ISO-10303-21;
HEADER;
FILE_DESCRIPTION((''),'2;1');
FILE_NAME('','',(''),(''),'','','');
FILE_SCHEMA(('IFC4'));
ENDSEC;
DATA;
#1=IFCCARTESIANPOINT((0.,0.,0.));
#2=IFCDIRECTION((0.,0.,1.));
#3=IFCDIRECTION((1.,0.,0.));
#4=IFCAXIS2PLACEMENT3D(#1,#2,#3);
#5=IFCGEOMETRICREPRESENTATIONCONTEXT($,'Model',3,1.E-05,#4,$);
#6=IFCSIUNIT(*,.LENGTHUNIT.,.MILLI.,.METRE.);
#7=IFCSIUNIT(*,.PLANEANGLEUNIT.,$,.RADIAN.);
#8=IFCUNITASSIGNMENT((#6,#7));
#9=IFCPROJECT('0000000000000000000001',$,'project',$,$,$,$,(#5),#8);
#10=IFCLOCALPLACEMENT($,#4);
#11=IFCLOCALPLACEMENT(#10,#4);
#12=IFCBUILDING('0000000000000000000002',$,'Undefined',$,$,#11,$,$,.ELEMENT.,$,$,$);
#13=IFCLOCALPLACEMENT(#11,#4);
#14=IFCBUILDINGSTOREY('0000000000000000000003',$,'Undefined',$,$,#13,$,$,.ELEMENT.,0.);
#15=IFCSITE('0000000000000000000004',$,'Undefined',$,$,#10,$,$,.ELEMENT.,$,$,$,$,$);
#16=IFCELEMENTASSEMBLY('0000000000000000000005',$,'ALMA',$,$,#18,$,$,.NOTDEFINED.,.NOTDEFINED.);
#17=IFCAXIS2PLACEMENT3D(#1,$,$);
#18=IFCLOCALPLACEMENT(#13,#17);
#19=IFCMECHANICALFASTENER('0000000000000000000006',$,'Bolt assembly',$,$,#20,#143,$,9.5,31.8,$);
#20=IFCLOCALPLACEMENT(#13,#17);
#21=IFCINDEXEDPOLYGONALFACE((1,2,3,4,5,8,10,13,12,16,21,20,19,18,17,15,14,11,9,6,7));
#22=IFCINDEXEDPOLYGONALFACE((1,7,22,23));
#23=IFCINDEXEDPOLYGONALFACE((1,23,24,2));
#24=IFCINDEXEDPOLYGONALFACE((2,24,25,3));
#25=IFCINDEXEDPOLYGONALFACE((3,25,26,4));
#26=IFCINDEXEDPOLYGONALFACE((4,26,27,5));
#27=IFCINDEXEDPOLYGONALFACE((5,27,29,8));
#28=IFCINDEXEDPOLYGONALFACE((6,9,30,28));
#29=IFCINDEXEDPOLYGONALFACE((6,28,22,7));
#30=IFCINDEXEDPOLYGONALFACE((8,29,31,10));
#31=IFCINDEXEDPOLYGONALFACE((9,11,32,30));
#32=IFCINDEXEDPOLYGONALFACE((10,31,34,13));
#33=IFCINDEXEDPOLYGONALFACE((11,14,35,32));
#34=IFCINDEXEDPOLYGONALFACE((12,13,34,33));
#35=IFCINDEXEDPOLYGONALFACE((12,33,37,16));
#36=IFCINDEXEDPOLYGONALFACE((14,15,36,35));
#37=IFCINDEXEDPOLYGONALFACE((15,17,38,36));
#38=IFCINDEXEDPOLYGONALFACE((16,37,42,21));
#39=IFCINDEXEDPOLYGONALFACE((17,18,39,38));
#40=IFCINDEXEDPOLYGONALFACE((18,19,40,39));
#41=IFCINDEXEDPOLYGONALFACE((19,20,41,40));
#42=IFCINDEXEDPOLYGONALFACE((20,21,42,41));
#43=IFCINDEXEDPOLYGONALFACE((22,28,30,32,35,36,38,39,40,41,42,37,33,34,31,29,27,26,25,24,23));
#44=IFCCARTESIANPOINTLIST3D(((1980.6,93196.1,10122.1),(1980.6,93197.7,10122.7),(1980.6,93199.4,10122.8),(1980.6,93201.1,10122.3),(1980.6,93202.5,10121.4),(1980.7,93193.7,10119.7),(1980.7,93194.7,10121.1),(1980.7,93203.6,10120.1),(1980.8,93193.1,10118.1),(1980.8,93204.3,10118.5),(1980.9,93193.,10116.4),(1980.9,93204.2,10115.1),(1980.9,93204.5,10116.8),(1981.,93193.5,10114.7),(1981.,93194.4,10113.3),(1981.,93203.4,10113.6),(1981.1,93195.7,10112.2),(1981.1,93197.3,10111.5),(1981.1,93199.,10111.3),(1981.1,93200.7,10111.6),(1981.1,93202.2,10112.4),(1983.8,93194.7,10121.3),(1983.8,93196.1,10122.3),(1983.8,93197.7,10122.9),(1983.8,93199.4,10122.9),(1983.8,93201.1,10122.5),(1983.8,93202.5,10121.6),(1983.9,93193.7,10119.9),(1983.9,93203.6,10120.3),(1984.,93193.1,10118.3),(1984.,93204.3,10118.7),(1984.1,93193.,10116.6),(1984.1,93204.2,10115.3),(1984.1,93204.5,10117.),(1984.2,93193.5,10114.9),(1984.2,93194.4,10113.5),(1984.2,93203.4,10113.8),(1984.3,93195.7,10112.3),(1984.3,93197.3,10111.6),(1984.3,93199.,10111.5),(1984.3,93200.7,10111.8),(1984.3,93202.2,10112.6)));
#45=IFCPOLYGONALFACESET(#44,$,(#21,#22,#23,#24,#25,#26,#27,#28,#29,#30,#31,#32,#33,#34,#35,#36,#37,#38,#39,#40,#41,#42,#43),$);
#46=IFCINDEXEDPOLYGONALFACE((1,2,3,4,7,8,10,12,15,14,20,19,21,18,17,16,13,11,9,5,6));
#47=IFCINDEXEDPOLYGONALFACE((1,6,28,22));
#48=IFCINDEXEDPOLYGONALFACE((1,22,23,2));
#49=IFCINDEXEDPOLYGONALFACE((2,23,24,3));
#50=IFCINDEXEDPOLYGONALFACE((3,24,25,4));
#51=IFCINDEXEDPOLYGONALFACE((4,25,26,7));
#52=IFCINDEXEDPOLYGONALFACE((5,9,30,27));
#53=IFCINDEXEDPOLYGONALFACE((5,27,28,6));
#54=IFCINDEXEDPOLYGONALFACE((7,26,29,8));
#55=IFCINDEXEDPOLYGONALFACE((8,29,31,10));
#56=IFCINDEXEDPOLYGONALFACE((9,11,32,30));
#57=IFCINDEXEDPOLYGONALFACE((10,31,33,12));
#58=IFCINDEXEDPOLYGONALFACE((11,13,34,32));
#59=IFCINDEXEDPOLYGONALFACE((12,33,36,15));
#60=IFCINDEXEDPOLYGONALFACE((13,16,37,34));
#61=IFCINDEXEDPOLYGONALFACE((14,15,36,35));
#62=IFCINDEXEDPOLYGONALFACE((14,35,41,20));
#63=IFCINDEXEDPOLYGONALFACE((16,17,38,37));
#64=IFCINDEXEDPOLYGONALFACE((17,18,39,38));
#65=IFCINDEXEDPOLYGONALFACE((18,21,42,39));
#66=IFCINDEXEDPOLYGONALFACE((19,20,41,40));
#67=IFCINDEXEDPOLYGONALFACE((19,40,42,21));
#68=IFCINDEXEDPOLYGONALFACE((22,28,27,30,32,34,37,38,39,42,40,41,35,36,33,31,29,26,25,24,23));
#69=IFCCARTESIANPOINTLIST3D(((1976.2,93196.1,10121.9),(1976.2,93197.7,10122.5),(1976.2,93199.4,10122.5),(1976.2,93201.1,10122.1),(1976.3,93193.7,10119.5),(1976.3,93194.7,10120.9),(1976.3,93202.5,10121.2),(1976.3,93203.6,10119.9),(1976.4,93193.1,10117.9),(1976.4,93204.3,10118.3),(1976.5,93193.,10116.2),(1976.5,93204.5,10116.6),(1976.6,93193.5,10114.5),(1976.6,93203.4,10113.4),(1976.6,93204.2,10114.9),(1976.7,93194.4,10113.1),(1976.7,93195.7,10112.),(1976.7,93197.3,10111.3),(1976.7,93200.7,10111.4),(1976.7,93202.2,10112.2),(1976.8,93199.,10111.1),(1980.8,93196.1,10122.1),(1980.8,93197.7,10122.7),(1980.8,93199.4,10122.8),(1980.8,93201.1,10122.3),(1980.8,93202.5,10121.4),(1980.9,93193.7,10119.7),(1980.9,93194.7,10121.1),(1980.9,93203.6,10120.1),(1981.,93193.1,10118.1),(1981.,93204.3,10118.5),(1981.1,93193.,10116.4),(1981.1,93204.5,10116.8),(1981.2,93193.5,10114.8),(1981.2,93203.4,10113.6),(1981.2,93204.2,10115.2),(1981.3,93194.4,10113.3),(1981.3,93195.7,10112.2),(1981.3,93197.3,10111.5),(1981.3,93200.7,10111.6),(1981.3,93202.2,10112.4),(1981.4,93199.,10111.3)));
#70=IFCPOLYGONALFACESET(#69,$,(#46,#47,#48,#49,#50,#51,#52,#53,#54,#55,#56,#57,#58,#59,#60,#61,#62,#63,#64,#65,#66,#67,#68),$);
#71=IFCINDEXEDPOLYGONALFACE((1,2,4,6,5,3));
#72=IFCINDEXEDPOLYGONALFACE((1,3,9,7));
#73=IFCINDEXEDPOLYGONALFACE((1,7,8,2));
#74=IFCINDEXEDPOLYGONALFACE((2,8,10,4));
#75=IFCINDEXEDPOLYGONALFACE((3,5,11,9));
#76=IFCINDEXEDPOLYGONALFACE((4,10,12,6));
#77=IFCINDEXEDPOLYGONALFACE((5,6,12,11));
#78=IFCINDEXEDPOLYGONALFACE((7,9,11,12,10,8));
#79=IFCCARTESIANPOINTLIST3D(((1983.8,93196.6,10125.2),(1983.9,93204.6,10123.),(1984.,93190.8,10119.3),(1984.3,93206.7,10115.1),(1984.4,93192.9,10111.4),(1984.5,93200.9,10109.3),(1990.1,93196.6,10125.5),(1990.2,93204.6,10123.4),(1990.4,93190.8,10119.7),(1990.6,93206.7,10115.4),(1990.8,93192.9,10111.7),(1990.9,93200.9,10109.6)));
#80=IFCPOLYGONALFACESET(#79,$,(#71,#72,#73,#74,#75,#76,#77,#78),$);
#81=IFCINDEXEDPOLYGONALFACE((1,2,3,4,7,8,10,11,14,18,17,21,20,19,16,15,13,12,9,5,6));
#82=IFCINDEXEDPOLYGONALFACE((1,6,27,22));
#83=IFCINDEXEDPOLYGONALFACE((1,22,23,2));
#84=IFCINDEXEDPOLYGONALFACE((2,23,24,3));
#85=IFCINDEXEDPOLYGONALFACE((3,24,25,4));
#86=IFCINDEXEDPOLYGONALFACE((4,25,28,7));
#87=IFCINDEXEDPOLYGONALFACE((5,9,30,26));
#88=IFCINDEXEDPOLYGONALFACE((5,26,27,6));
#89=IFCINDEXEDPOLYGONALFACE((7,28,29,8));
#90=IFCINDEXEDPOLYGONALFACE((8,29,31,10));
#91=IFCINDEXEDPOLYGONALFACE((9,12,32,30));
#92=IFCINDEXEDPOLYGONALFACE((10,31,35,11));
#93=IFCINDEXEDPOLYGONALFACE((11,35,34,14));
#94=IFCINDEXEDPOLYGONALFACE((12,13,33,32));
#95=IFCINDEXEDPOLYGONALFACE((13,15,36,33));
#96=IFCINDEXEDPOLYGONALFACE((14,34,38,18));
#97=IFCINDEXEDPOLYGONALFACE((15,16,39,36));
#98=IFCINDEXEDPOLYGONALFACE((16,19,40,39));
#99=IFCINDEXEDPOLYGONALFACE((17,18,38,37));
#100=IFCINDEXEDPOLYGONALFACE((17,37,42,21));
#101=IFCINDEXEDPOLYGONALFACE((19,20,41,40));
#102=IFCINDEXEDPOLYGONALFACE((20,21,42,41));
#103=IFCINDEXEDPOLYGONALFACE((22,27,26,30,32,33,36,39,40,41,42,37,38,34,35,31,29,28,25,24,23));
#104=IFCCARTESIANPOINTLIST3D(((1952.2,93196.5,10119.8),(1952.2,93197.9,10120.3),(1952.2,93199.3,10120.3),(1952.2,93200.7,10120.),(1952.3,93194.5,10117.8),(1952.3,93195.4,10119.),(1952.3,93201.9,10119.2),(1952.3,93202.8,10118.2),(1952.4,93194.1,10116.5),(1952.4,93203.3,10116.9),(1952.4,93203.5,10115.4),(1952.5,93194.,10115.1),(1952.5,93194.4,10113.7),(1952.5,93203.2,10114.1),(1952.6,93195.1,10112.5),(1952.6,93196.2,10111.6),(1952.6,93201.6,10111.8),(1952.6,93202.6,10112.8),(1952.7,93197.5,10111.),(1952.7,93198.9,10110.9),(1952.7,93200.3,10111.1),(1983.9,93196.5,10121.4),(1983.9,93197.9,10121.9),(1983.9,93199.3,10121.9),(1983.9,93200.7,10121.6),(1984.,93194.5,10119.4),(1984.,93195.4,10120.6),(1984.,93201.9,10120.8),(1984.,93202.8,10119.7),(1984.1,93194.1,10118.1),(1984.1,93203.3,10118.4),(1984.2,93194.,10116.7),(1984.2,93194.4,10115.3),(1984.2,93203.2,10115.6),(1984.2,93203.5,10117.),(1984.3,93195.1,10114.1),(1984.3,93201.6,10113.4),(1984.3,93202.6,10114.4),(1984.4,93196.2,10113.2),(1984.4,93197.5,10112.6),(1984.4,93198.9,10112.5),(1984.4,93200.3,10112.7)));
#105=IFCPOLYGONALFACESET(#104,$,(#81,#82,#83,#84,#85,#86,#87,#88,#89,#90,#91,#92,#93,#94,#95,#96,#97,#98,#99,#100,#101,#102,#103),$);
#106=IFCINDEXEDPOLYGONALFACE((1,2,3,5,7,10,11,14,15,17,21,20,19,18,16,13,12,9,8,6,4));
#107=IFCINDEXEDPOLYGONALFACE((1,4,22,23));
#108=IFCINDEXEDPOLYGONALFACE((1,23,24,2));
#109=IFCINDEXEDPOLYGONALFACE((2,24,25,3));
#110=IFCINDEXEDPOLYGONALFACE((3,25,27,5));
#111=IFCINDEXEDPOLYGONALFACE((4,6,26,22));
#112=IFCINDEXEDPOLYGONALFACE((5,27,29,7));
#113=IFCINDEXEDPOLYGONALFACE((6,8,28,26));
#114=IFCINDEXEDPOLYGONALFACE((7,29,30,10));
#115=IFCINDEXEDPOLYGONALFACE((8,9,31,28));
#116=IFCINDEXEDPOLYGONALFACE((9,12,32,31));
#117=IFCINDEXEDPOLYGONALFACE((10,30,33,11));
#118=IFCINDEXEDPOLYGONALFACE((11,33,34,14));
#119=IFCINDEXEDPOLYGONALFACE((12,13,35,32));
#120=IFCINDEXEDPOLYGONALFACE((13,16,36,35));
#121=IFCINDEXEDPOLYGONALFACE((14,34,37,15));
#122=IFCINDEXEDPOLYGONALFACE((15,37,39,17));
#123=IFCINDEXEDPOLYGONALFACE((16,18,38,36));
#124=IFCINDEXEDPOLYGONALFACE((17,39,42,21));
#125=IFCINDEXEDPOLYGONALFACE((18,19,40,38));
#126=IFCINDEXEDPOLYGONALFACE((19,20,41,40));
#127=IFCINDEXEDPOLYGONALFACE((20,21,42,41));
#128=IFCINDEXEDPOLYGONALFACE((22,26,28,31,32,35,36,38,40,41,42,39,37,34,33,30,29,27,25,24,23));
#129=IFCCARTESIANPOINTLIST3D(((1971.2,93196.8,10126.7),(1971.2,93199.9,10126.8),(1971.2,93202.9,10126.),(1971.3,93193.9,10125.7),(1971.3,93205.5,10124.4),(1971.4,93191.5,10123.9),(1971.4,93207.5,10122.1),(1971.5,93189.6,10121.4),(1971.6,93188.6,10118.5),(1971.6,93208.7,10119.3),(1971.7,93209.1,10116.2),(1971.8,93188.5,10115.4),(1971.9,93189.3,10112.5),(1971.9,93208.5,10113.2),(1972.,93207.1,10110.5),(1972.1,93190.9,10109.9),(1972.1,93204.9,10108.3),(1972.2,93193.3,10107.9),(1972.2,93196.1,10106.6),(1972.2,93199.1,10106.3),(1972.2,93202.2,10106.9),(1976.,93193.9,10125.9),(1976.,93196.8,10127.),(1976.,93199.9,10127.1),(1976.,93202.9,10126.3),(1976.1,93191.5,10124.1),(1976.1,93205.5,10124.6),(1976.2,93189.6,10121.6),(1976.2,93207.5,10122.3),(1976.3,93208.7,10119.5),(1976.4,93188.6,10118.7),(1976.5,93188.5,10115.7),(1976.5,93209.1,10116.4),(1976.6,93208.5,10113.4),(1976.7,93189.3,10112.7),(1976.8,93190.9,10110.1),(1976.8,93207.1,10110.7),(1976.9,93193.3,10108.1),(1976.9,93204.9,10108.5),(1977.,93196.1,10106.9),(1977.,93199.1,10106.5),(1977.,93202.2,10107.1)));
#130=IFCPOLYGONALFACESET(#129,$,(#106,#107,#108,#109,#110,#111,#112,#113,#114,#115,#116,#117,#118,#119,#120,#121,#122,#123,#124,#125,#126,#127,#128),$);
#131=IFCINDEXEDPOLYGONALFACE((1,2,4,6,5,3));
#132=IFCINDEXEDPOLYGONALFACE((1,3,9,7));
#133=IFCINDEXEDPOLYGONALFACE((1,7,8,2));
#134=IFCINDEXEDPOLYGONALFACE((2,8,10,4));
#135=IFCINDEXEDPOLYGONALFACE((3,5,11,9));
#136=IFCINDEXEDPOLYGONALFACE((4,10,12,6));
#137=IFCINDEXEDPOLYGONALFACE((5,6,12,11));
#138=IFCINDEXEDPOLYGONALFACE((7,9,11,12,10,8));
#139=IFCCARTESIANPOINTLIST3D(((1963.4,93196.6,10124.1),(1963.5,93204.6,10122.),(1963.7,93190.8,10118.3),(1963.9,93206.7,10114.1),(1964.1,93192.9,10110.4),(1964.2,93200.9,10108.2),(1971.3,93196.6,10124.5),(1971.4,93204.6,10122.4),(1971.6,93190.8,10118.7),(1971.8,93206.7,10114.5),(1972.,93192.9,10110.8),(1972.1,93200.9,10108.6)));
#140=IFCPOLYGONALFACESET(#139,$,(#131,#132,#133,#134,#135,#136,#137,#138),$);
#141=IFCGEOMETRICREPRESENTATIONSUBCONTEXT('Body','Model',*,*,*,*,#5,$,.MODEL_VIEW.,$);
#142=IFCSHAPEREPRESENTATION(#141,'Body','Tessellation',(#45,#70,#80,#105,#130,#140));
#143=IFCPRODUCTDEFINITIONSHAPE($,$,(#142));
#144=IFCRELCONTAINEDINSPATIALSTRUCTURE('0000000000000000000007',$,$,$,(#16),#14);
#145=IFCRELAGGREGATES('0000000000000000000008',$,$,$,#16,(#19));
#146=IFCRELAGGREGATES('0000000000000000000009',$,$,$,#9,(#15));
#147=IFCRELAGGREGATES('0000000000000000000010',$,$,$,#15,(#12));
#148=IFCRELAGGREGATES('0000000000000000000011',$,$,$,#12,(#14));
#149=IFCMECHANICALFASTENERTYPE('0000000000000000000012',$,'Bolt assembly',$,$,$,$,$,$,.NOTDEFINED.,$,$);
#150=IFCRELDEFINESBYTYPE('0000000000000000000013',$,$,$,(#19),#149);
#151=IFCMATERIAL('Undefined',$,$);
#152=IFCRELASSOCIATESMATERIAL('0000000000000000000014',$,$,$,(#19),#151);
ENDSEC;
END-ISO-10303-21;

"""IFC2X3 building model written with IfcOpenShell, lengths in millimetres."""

from ifc_helpers import new_model, si_unit, frame, origin_with_axes, origin_2d_with_axis, place, context, subcontext, project, spatial, polyline, circle, outline, extrude, source, transform, mapped, material, type_object, element, aggregate, save


model = new_model("IFC2X3")

# Units and contexts
model_context = context("Model", 3, precision=1e-05, world=origin_with_axes())
body_context = subcontext(model_context, "Body", "Model", "MODEL_VIEW")
ifc_project = project(units=[si_unit("LENGTHUNIT", "METRE", prefix="MILLI"), si_unit("PLANEANGLEUNIT", "RADIAN")], contexts=[model_context])

# Site, building, storey
site_placement = place(None, origin_with_axes())
site = spatial("IfcSite", under=ifc_project, at=site_placement, Name="Undefined", CompositionType="ELEMENT")
building_placement = place(site_placement, origin_with_axes())
building = spatial("IfcBuilding", under=site, at=building_placement, Name="Undefined", CompositionType="ELEMENT")
storey_placement = place(building_placement, origin_with_axes())
storey = spatial("IfcBuildingStorey", under=building, at=storey_placement, Name="Undefined", CompositionType="ELEMENT", Elevation=0.0)

# Element assembly
assembly_1_placement = place(storey_placement, origin_with_axes())
assembly_1 = element("IfcElementAssembly", 1, at=assembly_1_placement, inside=storey, Name="ALMA", AssemblyPlace="NOTDEFINED", PredefinedType="NOTDEFINED")

# Shared definitions
ifc_material_1 = material(Name="Undefined")
mechanical_fastener_type = type_object("IfcMechanicalFastenerType", Name="Bolt assembly")

# Mechanical fastener
shared_shape_1 = source(origin_with_axes(), body_context, "Body", "SweptSolid", [
    extrude(circle(Radius=5.8, at=origin_2d_with_axis()), frame((0.0, -7.6, 0.0), z_axis=(0.0, 1.0, 0.0), x_axis=(1.0, 0.0, 0.0)), (0.0, 0.0, 1.0), 3.2),
    extrude(circle(Radius=5.8, at=origin_2d_with_axis()), frame((0.0, -4.6, 0.0), z_axis=(0.0, 1.0, 0.0), x_axis=(1.0, 0.0, 0.0)), (0.0, 0.0, 1.0), 4.6),
    extrude(outline(polyline([(7.1, -4.1), (7.1, 4.1), (0.0, 8.2), (-7.1, 4.1), (-7.1, -4.1), (0.0, -8.2), (7.1, -4.1)])), frame((0.0, -14.0, 0.0), z_axis=(0.0, 1.0, 0.0), x_axis=(1.0, 0.0, 0.0)), (0.0, 0.0, 1.0), 6.3),
    extrude(circle(Radius=4.8, at=origin_2d_with_axis()), frame((0.0, -7.7, 0.0), z_axis=(0.0, 1.0, 0.0), x_axis=(1.0, 0.0, 0.0)), (0.0, 0.0, 1.0), 31.8),
    extrude(circle(Radius=10.3, at=origin_2d_with_axis()), frame((0.0, 0.0, 0.0), z_axis=(0.0, 1.0, 0.0), x_axis=(1.0, 0.0, 0.0)), (0.0, 0.0, 1.0), 4.8),
    extrude(outline(polyline([(7.1, -4.1), (7.1, 4.1), (0.0, 8.2), (-7.1, 4.1), (-7.1, -4.1), (0.0, -8.2), (7.1, -4.1)])), frame((0.0, 4.8, 0.0), z_axis=(0.0, 1.0, 0.0), x_axis=(1.0, 0.0, 0.0)), (0.0, 0.0, 1.0), 7.9),
])
mechanical_fastener_1_placement = place(assembly_1_placement, frame((1976.5, 93198.8, 10116.8), z_axis=(0.035282, -0.707107, -0.706226), x_axis=(-0.035282, -0.707107, 0.706226)))
mechanical_fastener_1 = element("IfcMechanicalFastener", 2, at=mechanical_fastener_1_placement, type_object=mechanical_fastener_type, material=ifc_material_1, Name="Bolt assembly", NominalDiameter=9.5, NominalLength=31.8, context=body_context, shape_type="MappedRepresentation", body=[
    mapped(shared_shape_1, transform((0.0, 0.0, 0.0))),
])
aggregate(assembly_1, [mechanical_fastener_1])

save(model, "model.ifc")
